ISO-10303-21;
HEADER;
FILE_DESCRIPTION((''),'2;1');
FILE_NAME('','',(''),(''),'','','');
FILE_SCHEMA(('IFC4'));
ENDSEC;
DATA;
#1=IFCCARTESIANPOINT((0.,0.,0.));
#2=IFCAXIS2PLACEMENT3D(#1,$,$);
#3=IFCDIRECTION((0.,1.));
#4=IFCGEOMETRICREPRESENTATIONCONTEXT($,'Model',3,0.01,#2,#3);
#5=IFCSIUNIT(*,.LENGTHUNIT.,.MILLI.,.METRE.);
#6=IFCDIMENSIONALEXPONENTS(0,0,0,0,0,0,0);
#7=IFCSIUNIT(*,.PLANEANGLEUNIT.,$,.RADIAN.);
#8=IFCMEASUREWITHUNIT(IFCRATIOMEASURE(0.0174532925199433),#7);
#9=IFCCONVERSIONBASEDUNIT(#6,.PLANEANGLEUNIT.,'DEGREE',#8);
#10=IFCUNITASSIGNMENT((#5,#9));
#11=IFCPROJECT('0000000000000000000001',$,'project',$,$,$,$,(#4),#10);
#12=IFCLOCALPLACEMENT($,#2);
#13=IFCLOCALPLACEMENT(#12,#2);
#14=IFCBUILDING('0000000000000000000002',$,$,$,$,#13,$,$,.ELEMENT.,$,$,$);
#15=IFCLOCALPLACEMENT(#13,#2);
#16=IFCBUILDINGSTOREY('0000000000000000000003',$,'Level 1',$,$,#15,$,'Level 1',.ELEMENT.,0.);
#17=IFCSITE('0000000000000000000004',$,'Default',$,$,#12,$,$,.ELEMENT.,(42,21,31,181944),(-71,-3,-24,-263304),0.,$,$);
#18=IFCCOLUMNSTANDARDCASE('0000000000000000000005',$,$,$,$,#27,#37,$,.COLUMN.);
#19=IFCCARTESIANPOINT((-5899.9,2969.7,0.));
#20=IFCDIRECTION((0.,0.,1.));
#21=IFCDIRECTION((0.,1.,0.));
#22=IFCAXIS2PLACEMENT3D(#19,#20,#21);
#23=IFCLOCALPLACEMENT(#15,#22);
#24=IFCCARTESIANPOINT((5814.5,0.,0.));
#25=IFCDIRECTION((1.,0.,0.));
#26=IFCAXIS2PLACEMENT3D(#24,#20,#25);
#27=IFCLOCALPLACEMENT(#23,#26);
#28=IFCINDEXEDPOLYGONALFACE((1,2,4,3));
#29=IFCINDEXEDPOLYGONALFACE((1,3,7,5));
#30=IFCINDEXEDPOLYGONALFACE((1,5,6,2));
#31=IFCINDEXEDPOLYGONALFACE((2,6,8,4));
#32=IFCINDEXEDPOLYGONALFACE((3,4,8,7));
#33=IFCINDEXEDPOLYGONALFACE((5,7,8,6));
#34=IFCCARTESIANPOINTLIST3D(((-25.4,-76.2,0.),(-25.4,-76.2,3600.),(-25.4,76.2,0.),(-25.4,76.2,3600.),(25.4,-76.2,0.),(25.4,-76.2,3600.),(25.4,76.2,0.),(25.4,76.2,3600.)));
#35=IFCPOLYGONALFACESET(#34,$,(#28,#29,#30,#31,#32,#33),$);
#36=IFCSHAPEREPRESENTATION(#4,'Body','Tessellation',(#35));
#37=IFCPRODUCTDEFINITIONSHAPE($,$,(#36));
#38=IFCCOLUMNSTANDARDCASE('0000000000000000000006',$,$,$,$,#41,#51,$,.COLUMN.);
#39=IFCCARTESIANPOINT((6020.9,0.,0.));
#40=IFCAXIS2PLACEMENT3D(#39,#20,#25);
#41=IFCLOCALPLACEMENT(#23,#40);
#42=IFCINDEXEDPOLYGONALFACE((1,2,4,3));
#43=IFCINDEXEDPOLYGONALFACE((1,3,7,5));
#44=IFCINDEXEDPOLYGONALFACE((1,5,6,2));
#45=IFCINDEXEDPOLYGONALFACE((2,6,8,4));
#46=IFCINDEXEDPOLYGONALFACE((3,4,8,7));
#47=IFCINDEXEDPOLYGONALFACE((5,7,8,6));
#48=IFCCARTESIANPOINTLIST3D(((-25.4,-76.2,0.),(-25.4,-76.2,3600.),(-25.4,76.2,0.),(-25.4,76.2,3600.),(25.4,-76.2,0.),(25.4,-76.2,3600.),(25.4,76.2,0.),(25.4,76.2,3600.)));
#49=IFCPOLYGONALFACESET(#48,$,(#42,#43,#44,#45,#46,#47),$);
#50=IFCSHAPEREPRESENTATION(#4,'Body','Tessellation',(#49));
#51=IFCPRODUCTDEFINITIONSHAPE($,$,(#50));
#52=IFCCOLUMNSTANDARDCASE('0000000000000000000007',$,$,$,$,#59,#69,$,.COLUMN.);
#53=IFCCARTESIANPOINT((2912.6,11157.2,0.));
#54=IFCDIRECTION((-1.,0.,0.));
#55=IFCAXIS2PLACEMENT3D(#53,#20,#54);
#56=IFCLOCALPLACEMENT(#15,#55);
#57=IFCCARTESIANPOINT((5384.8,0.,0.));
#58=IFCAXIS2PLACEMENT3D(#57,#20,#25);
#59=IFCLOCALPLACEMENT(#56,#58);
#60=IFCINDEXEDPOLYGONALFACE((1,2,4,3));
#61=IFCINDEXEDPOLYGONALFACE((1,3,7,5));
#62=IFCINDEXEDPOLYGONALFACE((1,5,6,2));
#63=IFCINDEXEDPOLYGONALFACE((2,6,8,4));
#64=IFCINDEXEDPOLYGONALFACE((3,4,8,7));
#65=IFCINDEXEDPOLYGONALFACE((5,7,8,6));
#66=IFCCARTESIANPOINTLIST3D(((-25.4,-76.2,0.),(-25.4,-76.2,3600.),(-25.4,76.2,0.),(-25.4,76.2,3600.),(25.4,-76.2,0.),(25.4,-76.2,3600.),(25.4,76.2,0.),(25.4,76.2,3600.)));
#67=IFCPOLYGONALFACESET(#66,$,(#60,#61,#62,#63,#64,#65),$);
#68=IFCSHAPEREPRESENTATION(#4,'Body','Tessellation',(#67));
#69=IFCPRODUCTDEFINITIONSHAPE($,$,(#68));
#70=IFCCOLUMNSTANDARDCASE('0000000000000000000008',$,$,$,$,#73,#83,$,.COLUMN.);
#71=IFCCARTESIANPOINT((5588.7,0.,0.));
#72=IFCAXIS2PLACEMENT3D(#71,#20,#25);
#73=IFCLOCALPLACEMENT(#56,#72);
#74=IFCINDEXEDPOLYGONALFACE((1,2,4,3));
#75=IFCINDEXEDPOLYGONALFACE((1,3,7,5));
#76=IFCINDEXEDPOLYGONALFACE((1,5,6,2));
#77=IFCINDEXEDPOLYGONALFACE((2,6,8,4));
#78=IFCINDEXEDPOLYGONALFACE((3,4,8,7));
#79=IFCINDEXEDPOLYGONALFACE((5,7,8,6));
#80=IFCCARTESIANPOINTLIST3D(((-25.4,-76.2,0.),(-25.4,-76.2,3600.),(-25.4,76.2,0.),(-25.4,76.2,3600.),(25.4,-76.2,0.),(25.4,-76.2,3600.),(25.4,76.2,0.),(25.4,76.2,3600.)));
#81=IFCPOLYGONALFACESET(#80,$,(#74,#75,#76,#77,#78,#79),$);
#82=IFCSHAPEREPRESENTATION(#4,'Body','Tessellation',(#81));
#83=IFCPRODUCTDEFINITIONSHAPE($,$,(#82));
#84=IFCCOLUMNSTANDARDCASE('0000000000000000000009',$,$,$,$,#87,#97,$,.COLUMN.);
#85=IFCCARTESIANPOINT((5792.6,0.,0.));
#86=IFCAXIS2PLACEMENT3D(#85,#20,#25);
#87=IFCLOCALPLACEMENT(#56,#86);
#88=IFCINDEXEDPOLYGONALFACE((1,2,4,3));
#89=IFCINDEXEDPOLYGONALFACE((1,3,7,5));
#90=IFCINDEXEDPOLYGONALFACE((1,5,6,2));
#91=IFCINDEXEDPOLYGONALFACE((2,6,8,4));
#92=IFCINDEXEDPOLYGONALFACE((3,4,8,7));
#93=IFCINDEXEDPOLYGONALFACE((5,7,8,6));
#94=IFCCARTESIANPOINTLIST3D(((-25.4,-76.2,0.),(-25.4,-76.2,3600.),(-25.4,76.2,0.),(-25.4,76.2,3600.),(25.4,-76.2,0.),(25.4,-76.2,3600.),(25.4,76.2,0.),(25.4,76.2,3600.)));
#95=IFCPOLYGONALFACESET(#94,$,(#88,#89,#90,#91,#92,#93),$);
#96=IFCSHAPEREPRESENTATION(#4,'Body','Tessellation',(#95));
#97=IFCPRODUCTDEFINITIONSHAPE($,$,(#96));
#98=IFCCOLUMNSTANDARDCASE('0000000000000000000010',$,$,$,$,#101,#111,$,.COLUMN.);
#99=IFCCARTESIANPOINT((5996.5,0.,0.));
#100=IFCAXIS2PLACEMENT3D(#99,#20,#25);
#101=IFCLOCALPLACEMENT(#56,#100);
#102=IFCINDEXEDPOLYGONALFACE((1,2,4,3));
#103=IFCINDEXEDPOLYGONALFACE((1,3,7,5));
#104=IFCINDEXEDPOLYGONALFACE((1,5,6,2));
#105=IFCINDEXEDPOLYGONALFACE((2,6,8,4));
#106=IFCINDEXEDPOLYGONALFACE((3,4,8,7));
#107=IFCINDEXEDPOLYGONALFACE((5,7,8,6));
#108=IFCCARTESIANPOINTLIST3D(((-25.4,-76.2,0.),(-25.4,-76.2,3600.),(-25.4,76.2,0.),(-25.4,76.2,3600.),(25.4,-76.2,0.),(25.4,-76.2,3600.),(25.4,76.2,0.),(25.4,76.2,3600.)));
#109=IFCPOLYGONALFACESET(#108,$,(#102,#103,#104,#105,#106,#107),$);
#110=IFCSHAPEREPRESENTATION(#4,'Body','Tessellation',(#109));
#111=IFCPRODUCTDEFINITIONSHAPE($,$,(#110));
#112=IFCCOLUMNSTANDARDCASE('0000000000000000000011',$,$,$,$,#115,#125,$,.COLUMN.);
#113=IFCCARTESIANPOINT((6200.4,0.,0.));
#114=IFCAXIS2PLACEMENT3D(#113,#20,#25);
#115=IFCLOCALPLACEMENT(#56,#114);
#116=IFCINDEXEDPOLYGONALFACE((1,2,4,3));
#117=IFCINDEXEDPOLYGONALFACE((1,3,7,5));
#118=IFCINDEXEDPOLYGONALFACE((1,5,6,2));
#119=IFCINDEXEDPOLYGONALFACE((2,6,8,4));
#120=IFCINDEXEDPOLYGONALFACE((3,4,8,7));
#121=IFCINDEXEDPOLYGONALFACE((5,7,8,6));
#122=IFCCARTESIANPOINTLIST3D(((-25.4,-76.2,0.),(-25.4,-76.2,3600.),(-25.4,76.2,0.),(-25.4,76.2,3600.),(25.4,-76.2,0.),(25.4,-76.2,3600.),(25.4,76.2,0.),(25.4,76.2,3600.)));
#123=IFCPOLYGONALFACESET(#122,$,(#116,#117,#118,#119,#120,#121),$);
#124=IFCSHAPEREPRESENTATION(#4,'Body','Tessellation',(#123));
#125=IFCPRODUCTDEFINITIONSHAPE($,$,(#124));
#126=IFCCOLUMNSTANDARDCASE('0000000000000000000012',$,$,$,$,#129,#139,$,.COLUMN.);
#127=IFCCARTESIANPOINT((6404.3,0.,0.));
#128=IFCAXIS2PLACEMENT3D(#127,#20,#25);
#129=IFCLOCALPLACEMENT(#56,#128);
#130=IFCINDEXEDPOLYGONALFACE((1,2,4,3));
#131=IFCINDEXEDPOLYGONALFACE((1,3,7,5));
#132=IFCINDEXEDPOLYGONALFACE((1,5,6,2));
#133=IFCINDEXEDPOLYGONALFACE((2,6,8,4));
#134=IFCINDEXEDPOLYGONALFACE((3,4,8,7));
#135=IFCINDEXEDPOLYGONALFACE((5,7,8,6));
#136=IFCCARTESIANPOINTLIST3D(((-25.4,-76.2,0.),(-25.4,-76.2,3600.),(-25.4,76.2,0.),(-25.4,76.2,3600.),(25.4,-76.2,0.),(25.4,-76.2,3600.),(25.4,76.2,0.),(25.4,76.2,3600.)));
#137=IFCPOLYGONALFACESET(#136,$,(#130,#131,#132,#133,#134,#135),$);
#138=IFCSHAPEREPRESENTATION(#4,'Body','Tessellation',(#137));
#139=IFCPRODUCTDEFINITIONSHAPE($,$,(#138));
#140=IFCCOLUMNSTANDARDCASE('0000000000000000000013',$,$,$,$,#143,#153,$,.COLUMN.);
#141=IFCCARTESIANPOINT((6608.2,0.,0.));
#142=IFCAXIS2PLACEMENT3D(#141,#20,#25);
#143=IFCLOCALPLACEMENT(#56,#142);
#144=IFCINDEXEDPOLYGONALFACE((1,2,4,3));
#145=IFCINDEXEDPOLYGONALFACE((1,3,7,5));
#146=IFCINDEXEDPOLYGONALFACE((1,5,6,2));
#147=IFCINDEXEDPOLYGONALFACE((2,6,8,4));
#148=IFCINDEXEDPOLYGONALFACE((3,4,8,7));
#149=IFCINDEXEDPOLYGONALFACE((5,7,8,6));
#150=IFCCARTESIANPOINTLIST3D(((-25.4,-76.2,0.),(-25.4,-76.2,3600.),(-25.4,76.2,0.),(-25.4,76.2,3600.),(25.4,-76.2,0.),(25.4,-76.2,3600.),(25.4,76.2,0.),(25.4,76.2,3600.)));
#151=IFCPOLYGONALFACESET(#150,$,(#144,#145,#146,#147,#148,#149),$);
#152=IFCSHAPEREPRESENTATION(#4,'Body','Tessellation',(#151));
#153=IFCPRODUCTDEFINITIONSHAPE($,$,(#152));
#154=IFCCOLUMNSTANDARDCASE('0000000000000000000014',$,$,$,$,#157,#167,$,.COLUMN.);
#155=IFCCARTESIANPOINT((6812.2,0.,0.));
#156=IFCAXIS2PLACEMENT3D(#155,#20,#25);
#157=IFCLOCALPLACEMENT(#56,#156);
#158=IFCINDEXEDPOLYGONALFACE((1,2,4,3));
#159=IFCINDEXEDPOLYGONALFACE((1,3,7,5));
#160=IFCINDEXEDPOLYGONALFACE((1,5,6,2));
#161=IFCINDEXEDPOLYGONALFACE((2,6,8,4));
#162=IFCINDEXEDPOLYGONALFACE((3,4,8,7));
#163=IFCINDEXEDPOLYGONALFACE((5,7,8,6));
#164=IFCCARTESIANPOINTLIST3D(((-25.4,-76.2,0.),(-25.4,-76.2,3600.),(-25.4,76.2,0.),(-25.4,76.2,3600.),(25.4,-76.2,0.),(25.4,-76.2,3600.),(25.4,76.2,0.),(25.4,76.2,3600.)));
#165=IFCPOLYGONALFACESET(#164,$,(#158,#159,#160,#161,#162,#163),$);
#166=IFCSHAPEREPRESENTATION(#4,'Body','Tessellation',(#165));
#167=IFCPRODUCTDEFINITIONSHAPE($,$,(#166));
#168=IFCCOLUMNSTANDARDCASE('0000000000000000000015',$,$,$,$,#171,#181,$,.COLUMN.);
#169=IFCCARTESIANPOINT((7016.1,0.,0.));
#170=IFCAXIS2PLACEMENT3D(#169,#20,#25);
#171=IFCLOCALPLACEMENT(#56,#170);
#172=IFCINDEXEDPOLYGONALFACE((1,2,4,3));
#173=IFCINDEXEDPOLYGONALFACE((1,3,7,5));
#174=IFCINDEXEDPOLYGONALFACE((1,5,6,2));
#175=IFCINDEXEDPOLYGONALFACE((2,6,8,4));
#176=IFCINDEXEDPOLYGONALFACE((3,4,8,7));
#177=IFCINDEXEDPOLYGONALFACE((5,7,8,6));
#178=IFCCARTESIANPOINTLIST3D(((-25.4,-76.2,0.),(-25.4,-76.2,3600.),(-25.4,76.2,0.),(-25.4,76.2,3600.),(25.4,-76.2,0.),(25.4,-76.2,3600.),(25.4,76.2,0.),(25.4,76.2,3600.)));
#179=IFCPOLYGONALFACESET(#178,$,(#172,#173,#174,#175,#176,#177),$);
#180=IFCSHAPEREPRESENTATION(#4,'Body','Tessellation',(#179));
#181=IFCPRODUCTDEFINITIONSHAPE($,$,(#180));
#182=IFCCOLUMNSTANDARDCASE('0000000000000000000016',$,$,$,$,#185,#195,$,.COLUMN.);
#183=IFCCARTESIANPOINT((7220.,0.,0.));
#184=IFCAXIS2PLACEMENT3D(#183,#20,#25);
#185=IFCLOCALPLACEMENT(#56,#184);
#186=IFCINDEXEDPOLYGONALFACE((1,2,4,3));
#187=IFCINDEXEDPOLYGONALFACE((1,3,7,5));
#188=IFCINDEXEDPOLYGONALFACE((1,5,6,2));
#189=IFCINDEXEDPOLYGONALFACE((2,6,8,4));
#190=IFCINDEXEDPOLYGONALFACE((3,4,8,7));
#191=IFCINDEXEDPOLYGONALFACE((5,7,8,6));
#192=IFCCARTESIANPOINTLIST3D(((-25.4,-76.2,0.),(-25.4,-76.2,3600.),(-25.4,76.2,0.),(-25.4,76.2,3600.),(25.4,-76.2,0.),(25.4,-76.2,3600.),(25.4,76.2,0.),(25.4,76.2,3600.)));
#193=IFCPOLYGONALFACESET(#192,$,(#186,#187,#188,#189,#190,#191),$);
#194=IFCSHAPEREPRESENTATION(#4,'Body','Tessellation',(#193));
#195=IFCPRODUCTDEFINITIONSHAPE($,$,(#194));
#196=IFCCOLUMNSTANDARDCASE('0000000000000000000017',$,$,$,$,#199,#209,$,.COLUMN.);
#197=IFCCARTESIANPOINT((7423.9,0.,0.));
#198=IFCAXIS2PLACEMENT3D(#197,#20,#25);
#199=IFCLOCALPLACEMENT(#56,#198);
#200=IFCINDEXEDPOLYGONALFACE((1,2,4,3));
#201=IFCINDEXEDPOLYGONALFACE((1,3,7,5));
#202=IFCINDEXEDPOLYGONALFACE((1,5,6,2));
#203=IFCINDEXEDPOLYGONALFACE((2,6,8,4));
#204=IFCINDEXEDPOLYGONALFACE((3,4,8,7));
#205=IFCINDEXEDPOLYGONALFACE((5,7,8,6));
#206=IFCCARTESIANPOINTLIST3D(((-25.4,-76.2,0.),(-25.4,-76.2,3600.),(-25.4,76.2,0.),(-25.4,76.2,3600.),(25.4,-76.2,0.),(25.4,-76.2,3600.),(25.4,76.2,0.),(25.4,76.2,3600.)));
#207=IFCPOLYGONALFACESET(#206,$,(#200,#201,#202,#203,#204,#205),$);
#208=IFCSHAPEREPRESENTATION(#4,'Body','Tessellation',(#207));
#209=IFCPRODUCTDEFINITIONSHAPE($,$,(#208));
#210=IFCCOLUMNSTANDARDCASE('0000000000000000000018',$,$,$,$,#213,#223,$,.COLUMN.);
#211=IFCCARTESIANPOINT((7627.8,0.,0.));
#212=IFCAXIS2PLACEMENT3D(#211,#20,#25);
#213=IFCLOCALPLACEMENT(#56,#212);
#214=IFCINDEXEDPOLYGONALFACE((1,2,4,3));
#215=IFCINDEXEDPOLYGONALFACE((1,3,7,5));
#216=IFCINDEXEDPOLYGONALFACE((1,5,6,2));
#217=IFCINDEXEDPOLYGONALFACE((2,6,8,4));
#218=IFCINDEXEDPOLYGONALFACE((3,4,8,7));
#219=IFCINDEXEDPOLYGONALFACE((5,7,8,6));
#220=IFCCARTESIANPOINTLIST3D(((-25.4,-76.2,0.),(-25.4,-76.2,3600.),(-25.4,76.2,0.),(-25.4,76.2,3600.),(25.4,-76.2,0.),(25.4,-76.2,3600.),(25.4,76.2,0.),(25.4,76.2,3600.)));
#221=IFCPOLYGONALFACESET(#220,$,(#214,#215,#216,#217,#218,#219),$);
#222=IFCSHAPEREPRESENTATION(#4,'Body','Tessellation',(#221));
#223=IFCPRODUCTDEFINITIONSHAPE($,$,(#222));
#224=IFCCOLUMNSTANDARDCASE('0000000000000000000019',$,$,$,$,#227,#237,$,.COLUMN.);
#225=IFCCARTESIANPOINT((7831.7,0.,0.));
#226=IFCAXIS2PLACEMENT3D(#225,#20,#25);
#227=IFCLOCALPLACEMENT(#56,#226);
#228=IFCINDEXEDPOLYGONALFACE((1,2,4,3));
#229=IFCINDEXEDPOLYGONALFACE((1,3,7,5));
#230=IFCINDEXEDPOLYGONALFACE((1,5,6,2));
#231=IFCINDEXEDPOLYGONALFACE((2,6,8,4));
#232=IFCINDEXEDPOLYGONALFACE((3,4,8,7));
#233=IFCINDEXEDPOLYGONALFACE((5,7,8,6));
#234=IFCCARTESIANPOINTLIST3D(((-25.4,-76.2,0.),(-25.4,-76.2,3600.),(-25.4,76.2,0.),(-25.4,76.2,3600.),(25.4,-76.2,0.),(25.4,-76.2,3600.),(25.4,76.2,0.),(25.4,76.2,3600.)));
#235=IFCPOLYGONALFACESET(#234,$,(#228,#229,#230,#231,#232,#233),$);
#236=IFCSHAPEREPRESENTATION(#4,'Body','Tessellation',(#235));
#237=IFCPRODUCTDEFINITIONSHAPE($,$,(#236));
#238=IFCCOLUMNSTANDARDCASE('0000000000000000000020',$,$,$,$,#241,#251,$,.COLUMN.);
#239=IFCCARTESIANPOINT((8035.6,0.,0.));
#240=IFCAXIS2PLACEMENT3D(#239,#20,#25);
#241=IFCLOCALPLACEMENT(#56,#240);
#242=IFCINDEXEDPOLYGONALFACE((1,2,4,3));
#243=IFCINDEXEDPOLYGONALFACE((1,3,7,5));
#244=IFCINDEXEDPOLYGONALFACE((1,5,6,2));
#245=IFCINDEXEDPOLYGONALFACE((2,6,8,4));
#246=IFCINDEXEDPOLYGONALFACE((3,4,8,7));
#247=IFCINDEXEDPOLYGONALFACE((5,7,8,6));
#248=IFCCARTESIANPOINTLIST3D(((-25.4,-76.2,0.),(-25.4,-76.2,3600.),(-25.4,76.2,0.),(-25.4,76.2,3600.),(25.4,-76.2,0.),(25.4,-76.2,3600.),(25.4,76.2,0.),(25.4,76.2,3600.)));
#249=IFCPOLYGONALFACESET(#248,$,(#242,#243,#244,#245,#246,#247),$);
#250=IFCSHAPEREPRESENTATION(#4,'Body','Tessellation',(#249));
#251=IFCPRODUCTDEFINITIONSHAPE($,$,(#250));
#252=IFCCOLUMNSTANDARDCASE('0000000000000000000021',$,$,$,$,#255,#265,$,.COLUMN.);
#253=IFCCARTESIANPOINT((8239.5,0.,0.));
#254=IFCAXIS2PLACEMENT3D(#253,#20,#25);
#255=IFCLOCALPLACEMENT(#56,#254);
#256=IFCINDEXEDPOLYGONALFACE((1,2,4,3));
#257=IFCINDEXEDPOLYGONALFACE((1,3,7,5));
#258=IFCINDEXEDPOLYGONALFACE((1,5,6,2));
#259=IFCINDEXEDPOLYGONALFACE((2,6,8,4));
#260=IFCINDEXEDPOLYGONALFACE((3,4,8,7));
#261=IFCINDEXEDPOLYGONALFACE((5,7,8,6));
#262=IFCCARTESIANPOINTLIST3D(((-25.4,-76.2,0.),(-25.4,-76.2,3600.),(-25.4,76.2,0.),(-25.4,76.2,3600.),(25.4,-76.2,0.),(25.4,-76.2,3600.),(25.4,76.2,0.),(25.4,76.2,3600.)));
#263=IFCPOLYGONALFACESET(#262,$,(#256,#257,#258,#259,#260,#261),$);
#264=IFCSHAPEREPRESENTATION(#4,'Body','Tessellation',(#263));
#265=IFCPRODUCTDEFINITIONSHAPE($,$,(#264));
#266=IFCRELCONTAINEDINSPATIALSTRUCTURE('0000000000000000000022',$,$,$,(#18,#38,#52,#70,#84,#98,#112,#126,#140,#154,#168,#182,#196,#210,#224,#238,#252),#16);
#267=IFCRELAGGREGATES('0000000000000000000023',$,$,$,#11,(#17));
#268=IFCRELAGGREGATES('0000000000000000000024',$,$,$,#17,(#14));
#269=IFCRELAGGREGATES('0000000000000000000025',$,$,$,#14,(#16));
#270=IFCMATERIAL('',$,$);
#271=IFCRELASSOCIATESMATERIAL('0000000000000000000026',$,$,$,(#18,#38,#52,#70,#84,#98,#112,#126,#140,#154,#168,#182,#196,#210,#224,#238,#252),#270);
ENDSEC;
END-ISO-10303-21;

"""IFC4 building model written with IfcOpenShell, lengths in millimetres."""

from ifc_helpers import new_model, entity, si_unit, converted_unit, direction, frame, origin, place, context, project, spatial, rectangle, extrude, material, element, save


model = new_model("IFC4")

# Units and contexts
model_context = context("Model", 3, precision=0.01, world=origin(), true_north=direction((0.0, 1.0)))
ifc_project = project(units=[si_unit("LENGTHUNIT", "METRE", prefix="MILLI"), converted_unit("PLANEANGLEUNIT", "DEGREE", entity("IfcRatioMeasure", 0.0174532925199433), si_unit("PLANEANGLEUNIT", "RADIAN"), dimensions=[0, 0, 0, 0, 0, 0, 0])], contexts=[model_context])

# Site, building, storey
site_placement = place(None, origin())
site = spatial("IfcSite", under=ifc_project, at=site_placement, Name="Default", CompositionType="ELEMENT", RefLatitude=(42, 21, 31, 181944), RefLongitude=(-71, -3, -24, -263304), RefElevation=0.0)
building_placement = place(site_placement, origin())
building = spatial("IfcBuilding", under=site, at=building_placement, CompositionType="ELEMENT")
storey_placement = place(building_placement, origin())
storey = spatial("IfcBuildingStorey", under=building, at=storey_placement, Name="Level 1", LongName="Level 1", CompositionType="ELEMENT", Elevation=0.0)

# Columns
ifc_material_1 = material(Name="")
placement_1 = place(storey_placement, frame((-5899.9, 2969.7, 0.0), z_axis=(0.0, 0.0, 1.0), x_axis=(0.0, 1.0, 0.0)))
for number, where, z_axis, x_axis in (
    (1, (5814.5, 0.0, 0.0), (0.0, 0.0, 1.0), (1.0, 0.0, 0.0)),
    (2, (6020.9, 0.0, 0.0), (0.0, 0.0, 1.0), (1.0, 0.0, 0.0)),
):
    element("IfcColumnStandardCase", number, at=place(placement_1, frame(where, z_axis=z_axis, x_axis=x_axis)), inside=storey, material=ifc_material_1, PredefinedType="COLUMN", context=model_context, shape_type="SweptSolid", body=[
        extrude(rectangle(XDim=50.8, YDim=152.4), origin(), (0.0, 0.0, 1.0), 3600.0),
    ])
placement_2 = place(storey_placement, frame((2912.6, 11157.2, 0.0), z_axis=(0.0, 0.0, 1.0), x_axis=(-1.0, 0.0, 0.0)))
for number, where, z_axis, x_axis in (
    (3, (5384.8, 0.0, 0.0), (0.0, 0.0, 1.0), (1.0, 0.0, 0.0)),
    (4, (5588.7, 0.0, 0.0), (0.0, 0.0, 1.0), (1.0, 0.0, 0.0)),
    (5, (5792.6, 0.0, 0.0), (0.0, 0.0, 1.0), (1.0, 0.0, 0.0)),
    (6, (5996.5, 0.0, 0.0), (0.0, 0.0, 1.0), (1.0, 0.0, 0.0)),
    (7, (6200.4, 0.0, 0.0), (0.0, 0.0, 1.0), (1.0, 0.0, 0.0)),
    (8, (6404.3, 0.0, 0.0), (0.0, 0.0, 1.0), (1.0, 0.0, 0.0)),
    (9, (6608.2, 0.0, 0.0), (0.0, 0.0, 1.0), (1.0, 0.0, 0.0)),
    (10, (6812.2, 0.0, 0.0), (0.0, 0.0, 1.0), (1.0, 0.0, 0.0)),
    (11, (7016.1, 0.0, 0.0), (0.0, 0.0, 1.0), (1.0, 0.0, 0.0)),
    (12, (7220.0, 0.0, 0.0), (0.0, 0.0, 1.0), (1.0, 0.0, 0.0)),
    (13, (7423.9, 0.0, 0.0), (0.0, 0.0, 1.0), (1.0, 0.0, 0.0)),
    (14, (7627.8, 0.0, 0.0), (0.0, 0.0, 1.0), (1.0, 0.0, 0.0)),
    (15, (7831.7, 0.0, 0.0), (0.0, 0.0, 1.0), (1.0, 0.0, 0.0)),
    (16, (8035.6, 0.0, 0.0), (0.0, 0.0, 1.0), (1.0, 0.0, 0.0)),
    (17, (8239.5, 0.0, 0.0), (0.0, 0.0, 1.0), (1.0, 0.0, 0.0)),
):
    element("IfcColumnStandardCase", number, at=place(placement_2, frame(where, z_axis=z_axis, x_axis=x_axis)), inside=storey, material=ifc_material_1, PredefinedType="COLUMN", context=model_context, shape_type="SweptSolid", body=[
        extrude(rectangle(XDim=50.8, YDim=152.4), origin(), (0.0, 0.0, 1.0), 3600.0),
    ])

save(model, "model.ifc")
